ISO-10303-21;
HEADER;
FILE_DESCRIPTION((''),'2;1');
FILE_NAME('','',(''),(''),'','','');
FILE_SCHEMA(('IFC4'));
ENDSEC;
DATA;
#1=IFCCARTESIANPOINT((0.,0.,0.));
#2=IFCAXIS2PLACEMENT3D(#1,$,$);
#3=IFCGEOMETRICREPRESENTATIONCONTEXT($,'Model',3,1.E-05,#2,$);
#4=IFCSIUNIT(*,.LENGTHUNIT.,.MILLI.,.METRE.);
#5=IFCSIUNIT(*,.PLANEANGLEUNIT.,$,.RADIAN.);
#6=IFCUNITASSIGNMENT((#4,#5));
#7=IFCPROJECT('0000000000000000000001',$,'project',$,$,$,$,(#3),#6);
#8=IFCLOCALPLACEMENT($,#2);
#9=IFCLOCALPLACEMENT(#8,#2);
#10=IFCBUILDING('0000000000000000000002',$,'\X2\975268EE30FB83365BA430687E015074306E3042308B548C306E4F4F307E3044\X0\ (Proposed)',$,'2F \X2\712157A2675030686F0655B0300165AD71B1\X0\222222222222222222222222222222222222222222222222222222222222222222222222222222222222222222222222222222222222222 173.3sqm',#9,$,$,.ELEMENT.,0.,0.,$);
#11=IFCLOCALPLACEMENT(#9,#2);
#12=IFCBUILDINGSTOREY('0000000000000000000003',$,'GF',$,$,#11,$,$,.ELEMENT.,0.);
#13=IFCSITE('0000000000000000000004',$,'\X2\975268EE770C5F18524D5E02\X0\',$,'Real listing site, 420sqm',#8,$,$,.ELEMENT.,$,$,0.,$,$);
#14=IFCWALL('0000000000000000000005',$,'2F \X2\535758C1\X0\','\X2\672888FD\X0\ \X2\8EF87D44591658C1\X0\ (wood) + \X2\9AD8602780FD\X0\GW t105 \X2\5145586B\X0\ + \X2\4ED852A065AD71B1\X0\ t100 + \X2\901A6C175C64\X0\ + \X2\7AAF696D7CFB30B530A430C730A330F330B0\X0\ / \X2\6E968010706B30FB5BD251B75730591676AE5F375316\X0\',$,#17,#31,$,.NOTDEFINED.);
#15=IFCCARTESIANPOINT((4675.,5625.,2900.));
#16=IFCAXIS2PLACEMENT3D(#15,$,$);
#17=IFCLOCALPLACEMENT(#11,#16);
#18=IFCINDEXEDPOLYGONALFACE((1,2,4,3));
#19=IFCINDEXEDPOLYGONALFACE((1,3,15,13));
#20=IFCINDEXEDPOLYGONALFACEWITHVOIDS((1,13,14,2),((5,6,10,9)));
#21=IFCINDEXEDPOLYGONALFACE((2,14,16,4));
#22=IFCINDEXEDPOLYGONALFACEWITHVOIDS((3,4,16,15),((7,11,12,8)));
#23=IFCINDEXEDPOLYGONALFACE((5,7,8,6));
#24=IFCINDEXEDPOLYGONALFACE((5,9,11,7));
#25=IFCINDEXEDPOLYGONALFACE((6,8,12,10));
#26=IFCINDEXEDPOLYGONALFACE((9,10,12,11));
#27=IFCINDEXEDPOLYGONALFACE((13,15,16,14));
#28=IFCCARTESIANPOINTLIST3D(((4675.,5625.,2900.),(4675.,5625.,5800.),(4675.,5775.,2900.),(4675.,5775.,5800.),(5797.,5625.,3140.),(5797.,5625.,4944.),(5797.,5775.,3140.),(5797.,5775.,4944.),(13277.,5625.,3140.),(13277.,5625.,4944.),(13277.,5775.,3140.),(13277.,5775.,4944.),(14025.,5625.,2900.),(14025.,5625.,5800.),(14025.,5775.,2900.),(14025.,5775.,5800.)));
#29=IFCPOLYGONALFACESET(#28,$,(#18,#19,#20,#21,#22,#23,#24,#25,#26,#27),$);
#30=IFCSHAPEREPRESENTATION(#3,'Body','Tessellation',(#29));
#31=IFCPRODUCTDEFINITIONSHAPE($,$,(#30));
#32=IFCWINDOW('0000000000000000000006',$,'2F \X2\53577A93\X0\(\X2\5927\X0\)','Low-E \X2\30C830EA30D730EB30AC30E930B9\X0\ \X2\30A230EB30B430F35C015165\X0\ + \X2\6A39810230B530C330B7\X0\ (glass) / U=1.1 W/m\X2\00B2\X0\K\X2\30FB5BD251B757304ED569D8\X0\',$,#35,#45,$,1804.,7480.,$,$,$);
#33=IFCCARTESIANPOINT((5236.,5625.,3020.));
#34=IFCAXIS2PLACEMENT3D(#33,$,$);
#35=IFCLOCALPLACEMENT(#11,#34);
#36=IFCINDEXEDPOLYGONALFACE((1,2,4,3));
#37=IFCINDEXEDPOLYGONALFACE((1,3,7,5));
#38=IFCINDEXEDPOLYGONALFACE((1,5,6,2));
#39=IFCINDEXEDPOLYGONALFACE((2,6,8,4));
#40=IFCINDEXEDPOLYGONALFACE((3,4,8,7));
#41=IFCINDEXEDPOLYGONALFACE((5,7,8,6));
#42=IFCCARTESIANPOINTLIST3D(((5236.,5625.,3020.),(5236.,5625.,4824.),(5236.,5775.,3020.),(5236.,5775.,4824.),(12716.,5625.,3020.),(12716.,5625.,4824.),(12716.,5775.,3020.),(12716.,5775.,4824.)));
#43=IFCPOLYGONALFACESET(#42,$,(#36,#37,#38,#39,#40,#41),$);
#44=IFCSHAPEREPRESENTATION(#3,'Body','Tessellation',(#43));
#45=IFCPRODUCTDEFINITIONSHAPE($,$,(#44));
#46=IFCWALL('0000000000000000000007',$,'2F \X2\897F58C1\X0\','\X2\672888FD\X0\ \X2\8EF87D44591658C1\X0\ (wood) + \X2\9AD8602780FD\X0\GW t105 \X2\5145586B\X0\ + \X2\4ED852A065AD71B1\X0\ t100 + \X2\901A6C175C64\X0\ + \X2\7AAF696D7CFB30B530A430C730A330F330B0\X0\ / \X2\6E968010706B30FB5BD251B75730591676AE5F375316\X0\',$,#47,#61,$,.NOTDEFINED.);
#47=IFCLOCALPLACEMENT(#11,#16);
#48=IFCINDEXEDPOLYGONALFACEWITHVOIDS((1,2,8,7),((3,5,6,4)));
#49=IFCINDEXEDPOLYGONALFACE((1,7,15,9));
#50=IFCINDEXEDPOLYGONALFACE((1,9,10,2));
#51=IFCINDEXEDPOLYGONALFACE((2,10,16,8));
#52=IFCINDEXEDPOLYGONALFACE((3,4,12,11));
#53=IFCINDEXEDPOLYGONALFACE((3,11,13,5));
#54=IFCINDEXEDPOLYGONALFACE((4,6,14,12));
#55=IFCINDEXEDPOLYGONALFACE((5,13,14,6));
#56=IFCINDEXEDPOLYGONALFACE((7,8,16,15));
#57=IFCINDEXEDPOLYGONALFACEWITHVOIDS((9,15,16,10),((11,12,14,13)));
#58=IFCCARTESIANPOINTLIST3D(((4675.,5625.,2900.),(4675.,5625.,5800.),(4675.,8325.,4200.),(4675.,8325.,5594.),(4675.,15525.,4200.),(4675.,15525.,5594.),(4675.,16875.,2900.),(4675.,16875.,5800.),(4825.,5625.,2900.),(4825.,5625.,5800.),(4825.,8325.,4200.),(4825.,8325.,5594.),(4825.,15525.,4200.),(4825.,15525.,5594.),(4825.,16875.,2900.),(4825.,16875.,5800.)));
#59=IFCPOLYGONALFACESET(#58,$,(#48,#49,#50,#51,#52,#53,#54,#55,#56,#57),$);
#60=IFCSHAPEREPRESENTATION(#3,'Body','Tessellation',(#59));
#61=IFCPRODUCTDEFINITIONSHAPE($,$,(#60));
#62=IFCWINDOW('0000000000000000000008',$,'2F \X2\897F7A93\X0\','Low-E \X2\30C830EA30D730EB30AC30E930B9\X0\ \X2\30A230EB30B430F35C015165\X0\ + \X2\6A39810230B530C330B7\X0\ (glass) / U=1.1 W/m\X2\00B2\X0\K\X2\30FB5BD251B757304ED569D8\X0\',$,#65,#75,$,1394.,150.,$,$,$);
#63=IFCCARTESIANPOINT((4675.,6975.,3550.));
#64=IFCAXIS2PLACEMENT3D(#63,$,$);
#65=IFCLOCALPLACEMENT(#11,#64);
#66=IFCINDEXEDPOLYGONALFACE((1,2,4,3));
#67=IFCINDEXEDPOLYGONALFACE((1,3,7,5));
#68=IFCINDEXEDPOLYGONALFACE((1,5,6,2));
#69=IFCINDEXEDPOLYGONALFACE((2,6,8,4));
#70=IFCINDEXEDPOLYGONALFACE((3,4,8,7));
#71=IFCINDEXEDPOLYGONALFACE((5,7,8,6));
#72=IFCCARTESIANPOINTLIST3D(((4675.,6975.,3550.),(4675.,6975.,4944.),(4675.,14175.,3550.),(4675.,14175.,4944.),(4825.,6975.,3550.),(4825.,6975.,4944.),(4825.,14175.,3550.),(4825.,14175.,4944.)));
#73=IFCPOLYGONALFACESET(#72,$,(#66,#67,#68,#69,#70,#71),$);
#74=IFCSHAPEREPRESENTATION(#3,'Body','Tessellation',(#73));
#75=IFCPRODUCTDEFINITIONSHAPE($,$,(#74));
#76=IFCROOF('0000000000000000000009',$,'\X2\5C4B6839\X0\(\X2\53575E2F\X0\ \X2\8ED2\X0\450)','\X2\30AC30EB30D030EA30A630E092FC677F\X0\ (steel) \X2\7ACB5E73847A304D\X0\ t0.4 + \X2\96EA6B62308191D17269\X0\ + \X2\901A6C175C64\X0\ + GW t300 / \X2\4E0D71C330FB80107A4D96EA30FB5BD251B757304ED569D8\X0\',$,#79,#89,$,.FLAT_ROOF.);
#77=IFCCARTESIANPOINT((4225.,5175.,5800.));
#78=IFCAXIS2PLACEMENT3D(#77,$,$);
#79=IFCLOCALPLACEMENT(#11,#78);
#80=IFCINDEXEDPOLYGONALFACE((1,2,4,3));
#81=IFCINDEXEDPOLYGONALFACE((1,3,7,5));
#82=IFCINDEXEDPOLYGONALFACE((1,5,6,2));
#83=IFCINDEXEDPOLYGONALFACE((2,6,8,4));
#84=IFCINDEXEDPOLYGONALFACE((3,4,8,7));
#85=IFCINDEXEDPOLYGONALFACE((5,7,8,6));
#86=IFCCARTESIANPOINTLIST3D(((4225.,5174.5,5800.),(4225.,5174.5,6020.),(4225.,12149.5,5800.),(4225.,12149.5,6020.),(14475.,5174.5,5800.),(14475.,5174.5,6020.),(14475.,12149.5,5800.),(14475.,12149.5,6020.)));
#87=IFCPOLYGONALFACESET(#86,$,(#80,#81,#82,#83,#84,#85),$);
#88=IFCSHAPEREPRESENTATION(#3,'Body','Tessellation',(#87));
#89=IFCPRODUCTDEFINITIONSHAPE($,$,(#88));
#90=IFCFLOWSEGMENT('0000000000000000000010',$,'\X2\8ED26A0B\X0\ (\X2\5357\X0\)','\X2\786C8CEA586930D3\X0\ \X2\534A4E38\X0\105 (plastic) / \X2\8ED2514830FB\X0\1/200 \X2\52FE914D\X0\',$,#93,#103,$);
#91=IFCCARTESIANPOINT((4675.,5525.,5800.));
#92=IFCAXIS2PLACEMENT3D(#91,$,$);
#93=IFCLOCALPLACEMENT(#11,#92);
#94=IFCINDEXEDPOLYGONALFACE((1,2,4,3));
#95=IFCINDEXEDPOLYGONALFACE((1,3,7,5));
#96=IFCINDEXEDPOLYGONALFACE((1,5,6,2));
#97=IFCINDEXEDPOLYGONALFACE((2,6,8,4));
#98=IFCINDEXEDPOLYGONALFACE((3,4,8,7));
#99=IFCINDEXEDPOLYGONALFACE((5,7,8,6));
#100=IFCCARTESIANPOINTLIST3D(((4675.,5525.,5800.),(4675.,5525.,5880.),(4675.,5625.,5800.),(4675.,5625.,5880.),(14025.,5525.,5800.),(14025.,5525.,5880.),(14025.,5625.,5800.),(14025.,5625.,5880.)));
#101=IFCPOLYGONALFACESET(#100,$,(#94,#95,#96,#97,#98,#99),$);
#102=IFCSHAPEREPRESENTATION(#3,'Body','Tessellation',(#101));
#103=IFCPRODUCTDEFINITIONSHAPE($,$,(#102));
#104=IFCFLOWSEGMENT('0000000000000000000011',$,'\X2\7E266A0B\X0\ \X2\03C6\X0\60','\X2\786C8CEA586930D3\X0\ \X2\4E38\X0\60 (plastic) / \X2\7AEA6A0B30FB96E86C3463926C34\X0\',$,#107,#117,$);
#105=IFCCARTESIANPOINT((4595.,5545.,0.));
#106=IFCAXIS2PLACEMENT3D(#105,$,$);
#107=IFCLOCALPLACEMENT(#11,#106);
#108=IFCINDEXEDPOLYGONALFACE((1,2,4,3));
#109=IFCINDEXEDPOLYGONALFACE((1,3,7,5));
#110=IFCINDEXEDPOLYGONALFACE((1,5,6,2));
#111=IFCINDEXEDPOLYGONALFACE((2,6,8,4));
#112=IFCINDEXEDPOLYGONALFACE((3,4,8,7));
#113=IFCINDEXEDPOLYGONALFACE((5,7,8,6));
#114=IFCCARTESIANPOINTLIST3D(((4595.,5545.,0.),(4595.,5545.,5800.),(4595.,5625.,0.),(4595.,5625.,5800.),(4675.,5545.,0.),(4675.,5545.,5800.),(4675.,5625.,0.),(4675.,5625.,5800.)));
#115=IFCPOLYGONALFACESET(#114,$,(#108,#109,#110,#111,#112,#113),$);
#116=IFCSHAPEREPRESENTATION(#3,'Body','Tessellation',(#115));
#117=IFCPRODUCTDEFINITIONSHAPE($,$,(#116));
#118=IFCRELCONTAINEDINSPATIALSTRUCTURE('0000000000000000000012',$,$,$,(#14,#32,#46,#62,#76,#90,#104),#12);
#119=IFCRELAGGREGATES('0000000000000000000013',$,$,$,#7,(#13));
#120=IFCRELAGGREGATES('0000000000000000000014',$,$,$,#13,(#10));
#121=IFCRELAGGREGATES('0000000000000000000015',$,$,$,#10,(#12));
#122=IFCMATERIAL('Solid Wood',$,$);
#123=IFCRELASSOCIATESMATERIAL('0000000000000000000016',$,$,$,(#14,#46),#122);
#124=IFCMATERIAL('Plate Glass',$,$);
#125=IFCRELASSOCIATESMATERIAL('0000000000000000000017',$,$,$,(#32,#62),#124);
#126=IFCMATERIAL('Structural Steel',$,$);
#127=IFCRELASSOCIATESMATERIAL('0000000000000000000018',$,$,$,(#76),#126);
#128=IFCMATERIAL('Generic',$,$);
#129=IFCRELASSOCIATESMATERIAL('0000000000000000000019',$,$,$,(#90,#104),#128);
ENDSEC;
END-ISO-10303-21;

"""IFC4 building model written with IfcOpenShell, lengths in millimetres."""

from ifc_helpers import new_model, si_unit, frame, frame_2d, origin, place, context, project, spatial, rectangle, extrude, material, element, fill, save


model = new_model("IFC4")

# Units and contexts
model_context = context("Model", 3, precision=1e-05, world=origin())
ifc_project = project(units=[si_unit("LENGTHUNIT", "METRE", prefix="MILLI"), si_unit("PLANEANGLEUNIT", "RADIAN")], contexts=[model_context])

# Site, building, storey
site_placement = place(None, origin())
site = spatial("IfcSite", under=ifc_project, at=site_placement, Name="青森県弘前市", ObjectType="Real listing site, 420sqm", CompositionType="ELEMENT", RefElevation=0.0)
building_placement = place(site_placement, origin())
building = spatial("IfcBuilding", under=site, at=building_placement, Name="青森・茶室と縁側のある和の住まい (Proposed)", ObjectType="2F 無垢材と漆喰、断熱222222222222222222222222222222222222222222222222222222222222222222222222222222222222222222222222222222222222222 173.3sqm", CompositionType="ELEMENT", ElevationOfRefHeight=0.0, ElevationOfTerrain=0.0)
storey_placement = place(building_placement, origin())
storey = spatial("IfcBuildingStorey", under=building, at=storey_placement, Name="GF", CompositionType="ELEMENT", Elevation=0.0)

# Shared definitions
ifc_material_1 = material(Name="Solid Wood")

# Shared definitions
ifc_material_2 = material(Name="Plate Glass")

# Walls, openings, windows
wall_1_placement = place(storey_placement, frame((4675.0, 5625.0, 2900.0)))
wall_1 = element("IfcWall", 1, at=wall_1_placement, inside=storey, material=ifc_material_1, Name="2F 南壁", Description="木製 軸組外壁 (wood) + 高性能GW t105 充填 + 付加断熱 t100 + 通気層 + 窯業系サイディング / 準耐火・寒冷地外皮強化", PredefinedType="NOTDEFINED", context=model_context, shape_type="SweptSolid", body=[
    extrude(rectangle(XDim=9350.0, YDim=150.0, at=frame_2d((4675.0, 75.0))), frame((4675.0, 5625.0, 2900.0)), (0.0, 0.0, 1.0), 2900.0),
])
opening_1_placement = place(storey_placement, frame((5236.0, 5625.0, 3020.0)))
opening_1 = element("IfcOpeningElement", 2, at=opening_1_placement, cuts=wall_1, PredefinedType="NOTDEFINED", context=model_context, shape_type="SweptSolid", body=[
    extrude(rectangle(XDim=7480.0, YDim=150.0, at=frame_2d((3740.0, 75.0))), frame((5236.0, 5625.0, 3020.0)), (0.0, 0.0, 1.0), 1804.0),
])
window_1_placement = place(storey_placement, frame((5236.0, 5625.0, 3020.0)))
window_1 = element("IfcWindow", 3, at=window_1_placement, inside=storey, material=ifc_material_2, Name="2F 南窓(大)", Description="Low-E トリプルガラス アルゴン封入 + 樹脂サッシ (glass) / U=1.1 W/m²K・寒冷地仕様", OverallHeight=1804.0, OverallWidth=7480.0, context=model_context, shape_type="SweptSolid", body=[
    extrude(rectangle(XDim=7480.0, YDim=150.0, at=frame_2d((3740.0, 75.0))), frame((5236.0, 5625.0, 3020.0)), (0.0, 0.0, 1.0), 1804.0),
])
fill(opening_1, window_1)
wall_2_placement = place(storey_placement, frame((4675.0, 5625.0, 2900.0)))
wall_2 = element("IfcWall", 4, at=wall_2_placement, inside=storey, material=ifc_material_1, Name="2F 西壁", Description="木製 軸組外壁 (wood) + 高性能GW t105 充填 + 付加断熱 t100 + 通気層 + 窯業系サイディング / 準耐火・寒冷地外皮強化", PredefinedType="NOTDEFINED", context=model_context, shape_type="SweptSolid", body=[
    extrude(rectangle(XDim=150.0, YDim=11250.0, at=frame_2d((75.0, 5625.0))), frame((4675.0, 5625.0, 2900.0)), (0.0, 0.0, 1.0), 2900.0),
])
opening_2_placement = place(storey_placement, frame((4675.0, 6975.0, 3550.0)))
opening_2 = element("IfcOpeningElement", 5, at=opening_2_placement, cuts=wall_2, PredefinedType="NOTDEFINED", context=model_context, shape_type="SweptSolid", body=[
    extrude(rectangle(XDim=150.0, YDim=7200.0, at=frame_2d((75.0, 3600.0))), frame((4675.0, 6975.0, 3550.0)), (0.0, 0.0, 1.0), 1394.0),
])
window_2_placement = place(storey_placement, frame((4675.0, 6975.0, 3550.0)))
window_2 = element("IfcWindow", 6, at=window_2_placement, inside=storey, material=ifc_material_2, Name="2F 西窓", Description="Low-E トリプルガラス アルゴン封入 + 樹脂サッシ (glass) / U=1.1 W/m²K・寒冷地仕様", OverallHeight=1394.0, OverallWidth=150.0, context=model_context, shape_type="SweptSolid", body=[
    extrude(rectangle(XDim=150.0, YDim=7200.0, at=frame_2d((75.0, 3600.0))), frame((4675.0, 6975.0, 3550.0)), (0.0, 0.0, 1.0), 1394.0),
])
fill(opening_2, window_2)

# Roof
ifc_material_3 = material(Name="Structural Steel")
for number, where, name in (
    (7, (4225.0, 5175.0, 5800.0), "屋根(南帯 軒450)"),
):
    element("IfcRoof", number, at=place(storey_placement, frame(where)), inside=storey, material=ifc_material_3, Name=name, Description="ガルバリウム鋼板 (steel) 立平葺き t0.4 + 雪止め金物 + 通気層 + GW t300 / 不燃・耐積雪・寒冷地仕様", PredefinedType="FLAT_ROOF", context=model_context, shape_type="SweptSolid", body=[
        extrude(rectangle(XDim=10250.0, YDim=6975.0, at=frame_2d((5125.0, 3487.0))), frame((4225.0, 5175.0, 5800.0)), (0.0, 0.0, 1.0), 220.0),
    ])

# Flow segments
ifc_material_4 = material(Name="Generic")
flow_segment_1_placement = place(storey_placement, frame((4675.0, 5525.0, 5800.0)))
element("IfcFlowSegment", 8, at=flow_segment_1_placement, inside=storey, material=ifc_material_4, Name="軒樋 (南)", Description="硬質塩ビ 半丸105 (plastic) / 軒先・1/200 勾配", context=model_context, shape_type="SweptSolid", body=[
    extrude(rectangle(XDim=9350.0, YDim=100.0, at=frame_2d((4675.0, 50.0))), frame((4675.0, 5525.0, 5800.0)), (0.0, 0.0, 1.0), 80.0),
])
flow_segment_2_placement = place(storey_placement, frame((4595.0, 5545.0, 0.0)))
element("IfcFlowSegment", 9, at=flow_segment_2_placement, inside=storey, material=ifc_material_4, Name="縦樋 φ60", Description="硬質塩ビ 丸60 (plastic) / 竪樋・雨水排水", context=model_context, shape_type="SweptSolid", body=[
    extrude(rectangle(XDim=80.0, YDim=80.0, at=frame_2d((40.0, 40.0))), frame((4595.0, 5545.0, 0.0)), (0.0, 0.0, 1.0), 5800.0),
])

save(model, "model.ifc")
